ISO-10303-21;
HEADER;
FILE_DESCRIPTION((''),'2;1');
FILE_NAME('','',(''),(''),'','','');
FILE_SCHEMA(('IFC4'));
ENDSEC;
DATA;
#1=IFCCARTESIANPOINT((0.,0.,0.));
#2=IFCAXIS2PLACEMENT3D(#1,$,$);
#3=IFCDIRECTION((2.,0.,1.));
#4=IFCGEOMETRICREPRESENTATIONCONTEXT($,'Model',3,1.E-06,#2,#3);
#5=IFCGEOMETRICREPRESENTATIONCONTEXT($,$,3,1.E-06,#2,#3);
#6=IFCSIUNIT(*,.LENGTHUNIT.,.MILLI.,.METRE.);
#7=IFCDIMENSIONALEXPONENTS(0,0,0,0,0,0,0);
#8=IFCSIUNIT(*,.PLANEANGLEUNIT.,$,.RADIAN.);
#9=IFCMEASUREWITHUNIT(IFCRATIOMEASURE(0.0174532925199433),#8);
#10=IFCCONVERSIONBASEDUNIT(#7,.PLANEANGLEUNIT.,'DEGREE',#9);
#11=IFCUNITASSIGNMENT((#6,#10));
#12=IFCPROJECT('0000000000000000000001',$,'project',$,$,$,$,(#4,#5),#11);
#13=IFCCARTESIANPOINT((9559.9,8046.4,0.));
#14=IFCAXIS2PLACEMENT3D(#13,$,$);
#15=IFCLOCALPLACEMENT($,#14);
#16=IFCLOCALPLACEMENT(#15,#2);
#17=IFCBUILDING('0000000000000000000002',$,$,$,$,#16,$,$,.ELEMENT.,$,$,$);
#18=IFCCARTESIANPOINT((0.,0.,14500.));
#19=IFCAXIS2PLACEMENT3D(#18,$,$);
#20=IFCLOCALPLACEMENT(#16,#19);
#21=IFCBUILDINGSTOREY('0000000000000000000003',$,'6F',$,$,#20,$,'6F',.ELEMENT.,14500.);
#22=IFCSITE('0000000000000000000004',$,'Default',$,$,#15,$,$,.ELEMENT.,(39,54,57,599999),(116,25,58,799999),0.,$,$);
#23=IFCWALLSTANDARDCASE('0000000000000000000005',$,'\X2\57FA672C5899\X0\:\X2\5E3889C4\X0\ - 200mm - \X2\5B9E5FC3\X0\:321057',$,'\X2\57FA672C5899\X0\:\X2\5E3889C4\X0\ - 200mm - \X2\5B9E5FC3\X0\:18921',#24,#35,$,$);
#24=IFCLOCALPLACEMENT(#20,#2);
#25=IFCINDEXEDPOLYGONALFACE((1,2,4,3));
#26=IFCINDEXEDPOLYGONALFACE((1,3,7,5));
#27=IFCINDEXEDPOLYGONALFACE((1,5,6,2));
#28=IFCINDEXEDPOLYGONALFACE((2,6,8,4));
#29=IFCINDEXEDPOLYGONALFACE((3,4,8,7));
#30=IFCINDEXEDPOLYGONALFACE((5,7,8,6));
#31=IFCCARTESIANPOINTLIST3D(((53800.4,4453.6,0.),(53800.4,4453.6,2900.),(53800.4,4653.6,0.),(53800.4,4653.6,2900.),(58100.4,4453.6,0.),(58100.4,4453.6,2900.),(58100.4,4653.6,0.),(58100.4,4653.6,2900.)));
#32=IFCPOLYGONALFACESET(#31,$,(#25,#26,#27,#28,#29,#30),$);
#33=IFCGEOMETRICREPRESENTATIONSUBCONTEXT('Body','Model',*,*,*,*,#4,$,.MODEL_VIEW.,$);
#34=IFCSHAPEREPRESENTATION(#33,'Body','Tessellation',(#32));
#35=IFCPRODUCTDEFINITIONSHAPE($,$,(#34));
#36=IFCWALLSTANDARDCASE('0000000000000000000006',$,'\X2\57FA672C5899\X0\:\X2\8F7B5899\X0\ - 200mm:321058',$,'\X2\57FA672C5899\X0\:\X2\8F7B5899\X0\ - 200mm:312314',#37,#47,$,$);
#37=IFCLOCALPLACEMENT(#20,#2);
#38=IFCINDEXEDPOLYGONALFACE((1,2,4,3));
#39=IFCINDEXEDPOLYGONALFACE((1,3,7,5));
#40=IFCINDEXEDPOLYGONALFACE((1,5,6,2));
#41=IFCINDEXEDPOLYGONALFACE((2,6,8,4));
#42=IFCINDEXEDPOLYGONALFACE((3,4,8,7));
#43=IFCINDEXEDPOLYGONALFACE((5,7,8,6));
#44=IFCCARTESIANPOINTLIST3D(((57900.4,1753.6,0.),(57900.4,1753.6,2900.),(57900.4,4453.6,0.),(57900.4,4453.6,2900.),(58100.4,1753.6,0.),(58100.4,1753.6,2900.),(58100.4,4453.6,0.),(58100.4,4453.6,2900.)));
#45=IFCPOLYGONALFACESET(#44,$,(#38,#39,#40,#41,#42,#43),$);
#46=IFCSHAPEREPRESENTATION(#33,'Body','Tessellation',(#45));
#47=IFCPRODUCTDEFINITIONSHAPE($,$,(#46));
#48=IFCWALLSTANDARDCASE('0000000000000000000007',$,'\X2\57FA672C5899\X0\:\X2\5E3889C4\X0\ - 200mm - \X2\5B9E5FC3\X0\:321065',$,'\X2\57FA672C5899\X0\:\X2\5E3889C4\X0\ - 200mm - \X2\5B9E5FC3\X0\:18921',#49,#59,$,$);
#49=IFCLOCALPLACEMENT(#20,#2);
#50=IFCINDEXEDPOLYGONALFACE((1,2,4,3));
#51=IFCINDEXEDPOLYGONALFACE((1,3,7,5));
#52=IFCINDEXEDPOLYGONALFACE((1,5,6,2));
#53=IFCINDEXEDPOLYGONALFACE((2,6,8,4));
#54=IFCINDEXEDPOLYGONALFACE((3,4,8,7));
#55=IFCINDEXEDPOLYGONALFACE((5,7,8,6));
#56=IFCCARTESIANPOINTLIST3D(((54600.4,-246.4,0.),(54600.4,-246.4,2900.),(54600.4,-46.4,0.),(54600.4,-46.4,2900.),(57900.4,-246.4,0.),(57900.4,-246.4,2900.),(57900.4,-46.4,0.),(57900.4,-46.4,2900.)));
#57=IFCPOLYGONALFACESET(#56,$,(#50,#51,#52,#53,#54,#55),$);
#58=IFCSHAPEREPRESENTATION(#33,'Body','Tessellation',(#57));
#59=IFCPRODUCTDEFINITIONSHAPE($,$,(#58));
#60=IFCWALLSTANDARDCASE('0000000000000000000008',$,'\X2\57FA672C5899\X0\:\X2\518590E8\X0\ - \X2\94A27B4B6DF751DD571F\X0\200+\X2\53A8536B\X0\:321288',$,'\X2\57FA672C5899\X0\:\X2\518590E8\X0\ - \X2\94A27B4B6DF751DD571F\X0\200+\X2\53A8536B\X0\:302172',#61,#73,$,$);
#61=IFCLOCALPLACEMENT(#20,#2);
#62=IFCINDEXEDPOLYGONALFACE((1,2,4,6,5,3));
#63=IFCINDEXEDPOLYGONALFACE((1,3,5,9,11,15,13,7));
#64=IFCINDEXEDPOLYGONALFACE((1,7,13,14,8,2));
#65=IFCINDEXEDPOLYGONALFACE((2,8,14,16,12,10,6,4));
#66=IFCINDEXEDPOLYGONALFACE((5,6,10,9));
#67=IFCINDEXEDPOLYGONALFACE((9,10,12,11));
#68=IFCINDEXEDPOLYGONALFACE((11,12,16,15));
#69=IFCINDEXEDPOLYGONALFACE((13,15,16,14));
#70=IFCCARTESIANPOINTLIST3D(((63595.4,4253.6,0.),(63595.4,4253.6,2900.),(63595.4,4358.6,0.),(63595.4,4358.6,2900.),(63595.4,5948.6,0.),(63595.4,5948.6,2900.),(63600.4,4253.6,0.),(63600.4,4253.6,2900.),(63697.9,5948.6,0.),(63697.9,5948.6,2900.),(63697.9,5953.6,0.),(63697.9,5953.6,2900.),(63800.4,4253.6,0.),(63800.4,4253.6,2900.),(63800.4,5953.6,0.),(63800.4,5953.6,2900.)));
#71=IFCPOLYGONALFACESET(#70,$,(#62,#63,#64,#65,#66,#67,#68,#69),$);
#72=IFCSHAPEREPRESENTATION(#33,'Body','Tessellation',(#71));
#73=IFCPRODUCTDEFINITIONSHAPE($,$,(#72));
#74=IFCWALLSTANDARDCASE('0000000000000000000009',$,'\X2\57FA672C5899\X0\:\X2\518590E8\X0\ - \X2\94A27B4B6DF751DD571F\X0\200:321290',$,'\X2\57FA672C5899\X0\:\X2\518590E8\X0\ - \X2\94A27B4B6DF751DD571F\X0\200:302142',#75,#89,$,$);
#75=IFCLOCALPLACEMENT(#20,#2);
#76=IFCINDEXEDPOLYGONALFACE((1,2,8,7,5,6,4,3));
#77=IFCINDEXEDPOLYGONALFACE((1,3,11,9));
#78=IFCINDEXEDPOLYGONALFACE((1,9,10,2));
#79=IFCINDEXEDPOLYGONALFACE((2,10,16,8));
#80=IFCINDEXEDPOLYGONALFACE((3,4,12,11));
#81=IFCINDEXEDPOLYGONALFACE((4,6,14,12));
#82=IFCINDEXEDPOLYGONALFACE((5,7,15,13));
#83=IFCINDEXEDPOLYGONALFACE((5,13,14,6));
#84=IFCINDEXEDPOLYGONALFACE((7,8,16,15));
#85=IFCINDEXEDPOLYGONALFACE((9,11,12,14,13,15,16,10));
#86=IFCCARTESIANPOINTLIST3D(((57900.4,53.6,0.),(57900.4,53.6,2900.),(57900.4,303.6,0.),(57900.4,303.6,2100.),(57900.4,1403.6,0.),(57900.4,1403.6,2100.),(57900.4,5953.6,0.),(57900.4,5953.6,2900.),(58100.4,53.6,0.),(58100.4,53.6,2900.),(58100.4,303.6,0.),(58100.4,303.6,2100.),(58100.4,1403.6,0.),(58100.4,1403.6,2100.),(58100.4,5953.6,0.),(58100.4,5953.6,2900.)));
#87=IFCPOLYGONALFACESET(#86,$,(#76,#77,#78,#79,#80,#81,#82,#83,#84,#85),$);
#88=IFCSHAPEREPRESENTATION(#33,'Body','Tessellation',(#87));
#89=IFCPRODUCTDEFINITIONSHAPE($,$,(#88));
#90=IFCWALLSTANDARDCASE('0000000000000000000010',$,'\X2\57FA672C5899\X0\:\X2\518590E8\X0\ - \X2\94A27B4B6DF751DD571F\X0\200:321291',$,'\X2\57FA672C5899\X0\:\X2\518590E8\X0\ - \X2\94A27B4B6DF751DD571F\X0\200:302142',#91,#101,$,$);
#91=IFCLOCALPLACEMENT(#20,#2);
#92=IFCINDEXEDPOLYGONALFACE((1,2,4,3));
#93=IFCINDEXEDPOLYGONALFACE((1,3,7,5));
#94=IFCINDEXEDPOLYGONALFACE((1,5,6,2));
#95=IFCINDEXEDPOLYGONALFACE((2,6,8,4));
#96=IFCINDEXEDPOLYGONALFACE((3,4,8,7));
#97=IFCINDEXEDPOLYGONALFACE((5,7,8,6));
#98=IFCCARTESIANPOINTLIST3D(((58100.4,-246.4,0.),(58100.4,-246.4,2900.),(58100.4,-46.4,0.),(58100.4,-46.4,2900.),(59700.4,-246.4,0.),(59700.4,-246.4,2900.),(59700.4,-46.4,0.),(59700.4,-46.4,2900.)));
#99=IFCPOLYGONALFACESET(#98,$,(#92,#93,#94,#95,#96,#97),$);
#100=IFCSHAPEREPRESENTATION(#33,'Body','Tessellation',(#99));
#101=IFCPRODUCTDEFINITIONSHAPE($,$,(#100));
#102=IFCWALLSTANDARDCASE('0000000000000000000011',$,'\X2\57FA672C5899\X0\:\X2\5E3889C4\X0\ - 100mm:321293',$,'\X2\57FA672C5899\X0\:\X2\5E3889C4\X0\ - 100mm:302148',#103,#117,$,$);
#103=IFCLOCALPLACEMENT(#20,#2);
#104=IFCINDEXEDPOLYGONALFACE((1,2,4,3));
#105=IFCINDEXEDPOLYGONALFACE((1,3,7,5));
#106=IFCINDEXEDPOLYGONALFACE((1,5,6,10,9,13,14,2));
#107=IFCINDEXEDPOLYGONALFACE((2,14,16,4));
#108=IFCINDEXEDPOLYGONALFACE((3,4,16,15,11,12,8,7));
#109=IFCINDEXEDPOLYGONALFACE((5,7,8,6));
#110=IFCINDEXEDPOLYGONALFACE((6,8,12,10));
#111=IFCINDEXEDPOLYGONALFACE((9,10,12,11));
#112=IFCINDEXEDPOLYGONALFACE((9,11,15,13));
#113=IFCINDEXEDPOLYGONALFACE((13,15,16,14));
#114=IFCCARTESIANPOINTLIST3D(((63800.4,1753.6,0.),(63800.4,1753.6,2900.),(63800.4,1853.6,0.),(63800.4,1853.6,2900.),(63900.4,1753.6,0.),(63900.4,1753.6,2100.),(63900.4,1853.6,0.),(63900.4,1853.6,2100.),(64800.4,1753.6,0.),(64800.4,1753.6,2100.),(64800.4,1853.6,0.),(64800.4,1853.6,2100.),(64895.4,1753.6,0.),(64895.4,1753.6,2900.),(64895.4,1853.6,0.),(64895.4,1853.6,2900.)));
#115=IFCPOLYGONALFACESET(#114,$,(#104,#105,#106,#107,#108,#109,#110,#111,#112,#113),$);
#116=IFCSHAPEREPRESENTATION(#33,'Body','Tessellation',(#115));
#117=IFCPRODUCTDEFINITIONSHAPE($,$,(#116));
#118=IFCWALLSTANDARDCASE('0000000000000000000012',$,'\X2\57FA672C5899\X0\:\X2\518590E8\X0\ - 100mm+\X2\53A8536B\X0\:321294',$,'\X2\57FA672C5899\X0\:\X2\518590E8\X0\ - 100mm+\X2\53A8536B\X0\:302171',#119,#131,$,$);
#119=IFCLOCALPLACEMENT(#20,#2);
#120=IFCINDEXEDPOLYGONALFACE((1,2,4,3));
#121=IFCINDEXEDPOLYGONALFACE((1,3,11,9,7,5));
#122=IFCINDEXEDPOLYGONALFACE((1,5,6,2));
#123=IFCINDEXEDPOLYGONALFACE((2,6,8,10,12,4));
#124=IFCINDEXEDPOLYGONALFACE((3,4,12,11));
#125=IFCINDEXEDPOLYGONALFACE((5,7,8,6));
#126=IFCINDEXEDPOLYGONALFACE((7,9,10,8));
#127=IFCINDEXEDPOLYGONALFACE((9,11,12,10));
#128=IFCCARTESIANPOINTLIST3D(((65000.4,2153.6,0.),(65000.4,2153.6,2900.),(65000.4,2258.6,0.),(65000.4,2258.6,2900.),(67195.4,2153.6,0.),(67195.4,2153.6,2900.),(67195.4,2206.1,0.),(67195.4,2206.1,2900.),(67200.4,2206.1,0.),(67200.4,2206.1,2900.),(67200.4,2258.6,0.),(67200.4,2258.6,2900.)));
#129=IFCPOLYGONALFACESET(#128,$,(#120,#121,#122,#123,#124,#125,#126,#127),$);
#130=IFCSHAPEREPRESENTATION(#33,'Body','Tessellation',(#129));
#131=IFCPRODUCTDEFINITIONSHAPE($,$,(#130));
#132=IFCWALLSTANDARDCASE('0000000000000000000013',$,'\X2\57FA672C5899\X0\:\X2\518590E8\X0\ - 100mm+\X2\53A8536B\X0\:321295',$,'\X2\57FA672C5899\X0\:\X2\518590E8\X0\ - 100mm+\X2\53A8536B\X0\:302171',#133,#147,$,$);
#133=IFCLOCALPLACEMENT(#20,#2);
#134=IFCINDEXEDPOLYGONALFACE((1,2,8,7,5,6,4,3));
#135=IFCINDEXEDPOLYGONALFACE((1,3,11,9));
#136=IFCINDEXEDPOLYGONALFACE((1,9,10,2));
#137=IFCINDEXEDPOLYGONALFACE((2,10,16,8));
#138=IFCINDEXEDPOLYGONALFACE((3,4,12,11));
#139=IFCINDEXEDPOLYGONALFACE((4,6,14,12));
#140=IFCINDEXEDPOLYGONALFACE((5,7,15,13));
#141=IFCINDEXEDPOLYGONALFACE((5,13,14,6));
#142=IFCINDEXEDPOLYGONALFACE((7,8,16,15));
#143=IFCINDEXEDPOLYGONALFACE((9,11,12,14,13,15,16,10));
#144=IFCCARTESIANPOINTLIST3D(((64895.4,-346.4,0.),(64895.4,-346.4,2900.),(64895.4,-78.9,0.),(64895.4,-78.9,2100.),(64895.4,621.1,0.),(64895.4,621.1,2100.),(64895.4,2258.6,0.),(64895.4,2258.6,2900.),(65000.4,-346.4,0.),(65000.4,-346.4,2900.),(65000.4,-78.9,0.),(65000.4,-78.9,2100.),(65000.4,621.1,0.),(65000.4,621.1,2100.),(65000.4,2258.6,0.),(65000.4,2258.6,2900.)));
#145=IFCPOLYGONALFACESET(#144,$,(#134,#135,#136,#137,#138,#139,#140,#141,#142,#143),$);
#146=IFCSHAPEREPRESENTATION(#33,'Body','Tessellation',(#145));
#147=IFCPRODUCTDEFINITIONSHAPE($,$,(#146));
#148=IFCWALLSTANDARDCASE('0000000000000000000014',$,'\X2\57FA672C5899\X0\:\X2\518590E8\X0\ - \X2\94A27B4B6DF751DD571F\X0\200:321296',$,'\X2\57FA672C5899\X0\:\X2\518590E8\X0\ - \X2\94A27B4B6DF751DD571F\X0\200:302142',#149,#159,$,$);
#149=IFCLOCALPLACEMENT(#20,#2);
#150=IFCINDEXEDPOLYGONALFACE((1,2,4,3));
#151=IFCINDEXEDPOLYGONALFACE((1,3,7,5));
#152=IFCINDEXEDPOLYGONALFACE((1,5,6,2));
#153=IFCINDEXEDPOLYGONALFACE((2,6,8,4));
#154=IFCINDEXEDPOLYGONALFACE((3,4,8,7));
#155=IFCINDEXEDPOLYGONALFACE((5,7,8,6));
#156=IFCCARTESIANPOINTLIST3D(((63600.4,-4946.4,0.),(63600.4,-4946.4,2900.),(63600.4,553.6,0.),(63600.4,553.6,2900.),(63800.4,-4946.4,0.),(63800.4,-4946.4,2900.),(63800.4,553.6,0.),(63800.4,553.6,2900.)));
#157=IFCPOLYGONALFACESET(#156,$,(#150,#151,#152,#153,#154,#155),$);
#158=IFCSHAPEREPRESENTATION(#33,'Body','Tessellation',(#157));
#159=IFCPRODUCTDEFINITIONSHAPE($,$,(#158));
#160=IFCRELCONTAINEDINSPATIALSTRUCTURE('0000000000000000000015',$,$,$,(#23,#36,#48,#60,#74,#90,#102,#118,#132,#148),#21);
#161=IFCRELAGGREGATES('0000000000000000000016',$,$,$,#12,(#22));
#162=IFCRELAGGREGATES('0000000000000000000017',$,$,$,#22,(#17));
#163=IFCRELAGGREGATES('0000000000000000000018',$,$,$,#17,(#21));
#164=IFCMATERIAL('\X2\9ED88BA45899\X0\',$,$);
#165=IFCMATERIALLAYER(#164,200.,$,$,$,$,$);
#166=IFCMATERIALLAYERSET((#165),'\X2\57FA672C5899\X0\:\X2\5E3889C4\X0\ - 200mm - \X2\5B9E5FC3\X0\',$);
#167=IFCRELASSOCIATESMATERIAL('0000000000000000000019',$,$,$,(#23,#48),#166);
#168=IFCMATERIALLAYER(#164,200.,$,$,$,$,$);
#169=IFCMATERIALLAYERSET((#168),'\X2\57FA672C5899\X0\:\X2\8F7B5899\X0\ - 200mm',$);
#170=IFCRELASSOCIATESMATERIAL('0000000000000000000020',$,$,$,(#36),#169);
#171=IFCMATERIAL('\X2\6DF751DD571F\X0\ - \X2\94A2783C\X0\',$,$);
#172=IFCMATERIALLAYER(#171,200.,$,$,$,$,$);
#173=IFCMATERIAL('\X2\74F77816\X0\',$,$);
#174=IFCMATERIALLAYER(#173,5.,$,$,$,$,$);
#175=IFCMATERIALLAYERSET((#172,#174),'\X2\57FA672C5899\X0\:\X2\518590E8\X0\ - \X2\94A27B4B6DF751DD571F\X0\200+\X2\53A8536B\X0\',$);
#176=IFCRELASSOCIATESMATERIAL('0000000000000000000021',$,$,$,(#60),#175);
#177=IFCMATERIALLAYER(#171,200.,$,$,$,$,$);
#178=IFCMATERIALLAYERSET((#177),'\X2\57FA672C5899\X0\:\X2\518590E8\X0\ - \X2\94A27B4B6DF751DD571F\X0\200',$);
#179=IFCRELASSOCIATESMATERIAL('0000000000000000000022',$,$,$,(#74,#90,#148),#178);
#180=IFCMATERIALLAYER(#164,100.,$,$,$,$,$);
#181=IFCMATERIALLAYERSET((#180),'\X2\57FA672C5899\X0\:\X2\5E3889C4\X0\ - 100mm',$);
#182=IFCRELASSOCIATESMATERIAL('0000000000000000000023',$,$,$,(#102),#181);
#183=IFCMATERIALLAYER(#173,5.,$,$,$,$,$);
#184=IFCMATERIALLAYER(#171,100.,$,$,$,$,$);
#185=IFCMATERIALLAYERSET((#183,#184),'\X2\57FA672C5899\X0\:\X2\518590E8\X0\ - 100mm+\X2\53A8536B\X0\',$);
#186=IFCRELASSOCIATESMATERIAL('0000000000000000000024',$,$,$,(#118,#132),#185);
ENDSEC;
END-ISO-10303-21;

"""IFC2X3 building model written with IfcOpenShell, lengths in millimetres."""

from ifc_helpers import new_model, entity, si_unit, converted_unit, direction, frame, frame_2d, origin, place, context, subcontext, project, spatial, polyline, rectangle, outline, extrude, material, layer, layer_set, layer_usage, element, save


model = new_model("IFC2X3")

# Units and contexts
model_context = context("Model", 3, precision=1e-06, world=origin(), true_north=direction((2.0, 0.0, 1.0)))
context_of_model = context(None, 3, precision=1e-06, world=origin(), true_north=direction((2.0, 0.0, 1.0)))
body_context = subcontext(model_context, "Body", "Model", "MODEL_VIEW")
ifc_project = project(units=[si_unit("LENGTHUNIT", "METRE", prefix="MILLI"), converted_unit("PLANEANGLEUNIT", "DEGREE", entity("IfcRatioMeasure", 0.0174532925199433), si_unit("PLANEANGLEUNIT", "RADIAN"), dimensions=[0, 0, 0, 0, 0, 0, 0])], contexts=[model_context, context_of_model])

# Site, building, storey
site_placement = place(None, frame((9559.9, 8046.4, 0.0)))
site = spatial("IfcSite", under=ifc_project, at=site_placement, Name="Default", CompositionType="ELEMENT", RefLatitude=(39, 54, 57, 599999), RefLongitude=(116, 25, 58, 799999), RefElevation=0.0)
building_placement = place(site_placement, origin())
building = spatial("IfcBuilding", under=site, at=building_placement, CompositionType="ELEMENT")
storey_placement = place(building_placement, frame((0.0, 0.0, 14500.0)))
storey = spatial("IfcBuildingStorey", under=building, at=storey_placement, Name="6F", LongName="6F", CompositionType="ELEMENT", Elevation=14500.0)

# Walls
ifc_material_1 = material(Name="默认墙")
ifc_layer_1 = layer(ifc_material_1, 200.0)
ifc_layer_set_1 = layer_set([ifc_layer_1], Name="基本墙:常规 - 200mm - 实心")
ifc_layer_usage_1 = layer_usage(ifc_layer_set_1, "AXIS2", "POSITIVE", -100.0)
wall_1_placement = place(storey_placement, frame((58100.4, 4553.6, 0.0), z_axis=(0.0, 0.0, 1.0), x_axis=(-1.0, 0.0, 0.0)))
element("IfcWallStandardCase", 1, at=wall_1_placement, inside=storey, material=ifc_layer_usage_1, Name="基本墙:常规 - 200mm - 实心:321057", ObjectType="基本墙:常规 - 200mm - 实心:18921", context=body_context, shape_type="SweptSolid", body=[
    extrude(rectangle(XDim=4300.0, YDim=200.0, at=frame_2d((2150.0, 0.0), x_axis=(-1.0, 0.0))), origin(), (0.0, 0.0, 1.0), 2900.0),
])
ifc_layer_2 = layer(ifc_material_1, 200.0)
ifc_layer_set_2 = layer_set([ifc_layer_2], Name="基本墙:轻墙 - 200mm")
ifc_layer_usage_2 = layer_usage(ifc_layer_set_2, "AXIS2", "POSITIVE", -100.0)
wall_2_placement = place(storey_placement, frame((58000.4, 4453.6, 0.0), z_axis=(0.0, 0.0, 1.0), x_axis=(0.0, -1.0, 0.0)))
element("IfcWallStandardCase", 2, at=wall_2_placement, inside=storey, material=ifc_layer_usage_2, Name="基本墙:轻墙 - 200mm:321058", ObjectType="基本墙:轻墙 - 200mm:312314", context=body_context, shape_type="SweptSolid", body=[
    extrude(rectangle(XDim=2700.0, YDim=200.0, at=frame_2d((1350.0, 0.0), x_axis=(-1.0, 0.0))), origin(), (0.0, 0.0, 1.0), 2900.0),
])
ifc_layer_usage_3 = layer_usage(ifc_layer_set_1, "AXIS2", "POSITIVE", -100.0)
wall_3_placement = place(storey_placement, frame((57900.4, -146.4, 0.0), z_axis=(0.0, 0.0, 1.0), x_axis=(-1.0, 0.0, 0.0)))
element("IfcWallStandardCase", 3, at=wall_3_placement, inside=storey, material=ifc_layer_usage_3, Name="基本墙:常规 - 200mm - 实心:321065", ObjectType="基本墙:常规 - 200mm - 实心:18921", context=body_context, shape_type="SweptSolid", body=[
    extrude(rectangle(XDim=3300.0, YDim=200.0, at=frame_2d((1650.0, 0.0), x_axis=(-1.0, 0.0))), origin(), (0.0, 0.0, 1.0), 2900.0),
])

# Shared definitions
ifc_material_2 = material(Name="混凝土 - 钢砼")

# Wall
ifc_layer_3 = layer(ifc_material_2, 200.0)
ifc_material_3 = material(Name="瓷砖")
ifc_layer_4 = layer(ifc_material_3, 5.0)
ifc_layer_set_3 = layer_set([ifc_layer_3, ifc_layer_4], Name="基本墙:内部 - 钢筋混凝土200+厨卫")
ifc_layer_usage_4 = layer_usage(ifc_layer_set_3, "AXIS2", "NEGATIVE", 102.5)
wall_4_placement = place(storey_placement, frame((63697.9, 5953.6, 0.0), z_axis=(0.0, 0.0, 1.0), x_axis=(0.0, -1.0, 0.0)))
element("IfcWallStandardCase", 4, at=wall_4_placement, inside=storey, material=ifc_layer_usage_4, Name="基本墙:内部 - 钢筋混凝土200+厨卫:321288", ObjectType="基本墙:内部 - 钢筋混凝土200+厨卫:302172", context=body_context, shape_type="SweptSolid", body=[
    extrude(outline(polyline([(1700.0, -102.5), (1700.0, -97.5), (1700.0, 102.5), (0.0, 102.5), (0.0, 0.0), (5.0, 0.0), (5.0, -102.5), (1595.0, -102.5), (1700.0, -102.5)])), origin(), (0.0, 0.0, 1.0), 2900.0),
])

# Wall, opening
ifc_layer_5 = layer(ifc_material_2, 200.0)
ifc_layer_set_4 = layer_set([ifc_layer_5], Name="基本墙:内部 - 钢筋混凝土200")
ifc_layer_usage_5 = layer_usage(ifc_layer_set_4, "AXIS2", "POSITIVE", -100.0)
wall_5_placement = place(storey_placement, frame((58000.4, 5953.6, 0.0), z_axis=(0.0, 0.0, 1.0), x_axis=(0.0, -1.0, 0.0)))
wall_5 = element("IfcWallStandardCase", 5, at=wall_5_placement, inside=storey, material=ifc_layer_usage_5, Name="基本墙:内部 - 钢筋混凝土200:321290", ObjectType="基本墙:内部 - 钢筋混凝土200:302142", context=body_context, shape_type="SweptSolid", body=[
    extrude(rectangle(XDim=5900.0, YDim=200.0, at=frame_2d((2950.0, 0.0), x_axis=(-1.0, 0.0))), origin(), (0.0, 0.0, 1.0), 2900.0),
])
opening_1_placement = place(wall_5_placement, frame((5650.0, 100.0, 0.0)))
element("IfcOpeningElement", 6, at=opening_1_placement, cuts=wall_5, ObjectType="Opening", context=body_context, shape_type="SweptSolid", body=[
    extrude(rectangle(XDim=2100.0, YDim=1100.0, at=frame_2d((1050.0, 550.0), x_axis=(1.0, 0.0))), frame((0.0, 0.0, 0.0), z_axis=(0.0, -1.0, 0.0), x_axis=(0.0, 0.0, 1.0)), (0.0, 0.0, 1.0), 200.0),
])

# Wall
ifc_layer_usage_6 = layer_usage(ifc_layer_set_4, "AXIS2", "POSITIVE", -100.0)
wall_6_placement = place(storey_placement, frame((58100.4, -146.4, 0.0)))
element("IfcWallStandardCase", 7, at=wall_6_placement, inside=storey, material=ifc_layer_usage_6, Name="基本墙:内部 - 钢筋混凝土200:321291", ObjectType="基本墙:内部 - 钢筋混凝土200:302142", context=body_context, shape_type="SweptSolid", body=[
    extrude(rectangle(XDim=1600.0, YDim=200.0, at=frame_2d((800.0, 0.0), x_axis=(-1.0, 0.0))), origin(), (0.0, 0.0, 1.0), 2900.0),
])

# Wall, opening
ifc_layer_6 = layer(ifc_material_1, 100.0)
ifc_layer_set_5 = layer_set([ifc_layer_6], Name="基本墙:常规 - 100mm")
ifc_layer_usage_7 = layer_usage(ifc_layer_set_5, "AXIS2", "POSITIVE", -50.0)
wall_7_placement = place(storey_placement, frame((64895.4, 1803.6, 0.0), z_axis=(0.0, 0.0, 1.0), x_axis=(-1.0, 0.0, 0.0)))
wall_7 = element("IfcWallStandardCase", 8, at=wall_7_placement, inside=storey, material=ifc_layer_usage_7, Name="基本墙:常规 - 100mm:321293", ObjectType="基本墙:常规 - 100mm:302148", context=body_context, shape_type="SweptSolid", body=[
    extrude(rectangle(XDim=1095.0, YDim=100.0, at=frame_2d((547.5, 0.0), x_axis=(-1.0, 0.0))), origin(), (0.0, 0.0, 1.0), 2900.0),
])
opening_2_placement = place(wall_7_placement, frame((995.0, 50.0, 0.0)))
element("IfcOpeningElement", 9, at=opening_2_placement, cuts=wall_7, ObjectType="Opening", context=body_context, shape_type="SweptSolid", body=[
    extrude(rectangle(XDim=2100.0, YDim=900.0, at=frame_2d((1050.0, 450.0), x_axis=(1.0, 0.0))), frame((0.0, 0.0, 0.0), z_axis=(0.0, -1.0, 0.0), x_axis=(0.0, 0.0, 1.0)), (0.0, 0.0, 1.0), 100.0),
])

# Wall
ifc_layer_7 = layer(ifc_material_3, 5.0)
ifc_layer_8 = layer(ifc_material_2, 100.0)
ifc_layer_set_6 = layer_set([ifc_layer_7, ifc_layer_8], Name="基本墙:内部 - 100mm+厨卫")
ifc_layer_usage_8 = layer_usage(ifc_layer_set_6, "AXIS2", "NEGATIVE", 52.5)
wall_8_placement = place(storey_placement, frame((67200.4, 2206.1, 0.0), z_axis=(0.0, 0.0, 1.0), x_axis=(-1.0, 0.0, 0.0)))
element("IfcWallStandardCase", 10, at=wall_8_placement, inside=storey, material=ifc_layer_usage_8, Name="基本墙:内部 - 100mm+厨卫:321294", ObjectType="基本墙:内部 - 100mm+厨卫:302171", context=body_context, shape_type="SweptSolid", body=[
    extrude(outline(polyline([(2200.0, -52.5), (2200.0, 52.5), (5.0, 52.5), (5.0, 0.0), (0.0, 0.0), (0.0, -52.5), (2200.0, -52.5)])), origin(), (0.0, 0.0, 1.0), 2900.0),
])

# Wall, opening
ifc_layer_usage_9 = layer_usage(ifc_layer_set_6, "AXIS2", "NEGATIVE", 52.5)
wall_9_placement = place(storey_placement, frame((64947.9, 2258.6, 0.0), z_axis=(0.0, 0.0, 1.0), x_axis=(0.0, -1.0, 0.0)))
wall_9 = element("IfcWallStandardCase", 11, at=wall_9_placement, inside=storey, material=ifc_layer_usage_9, Name="基本墙:内部 - 100mm+厨卫:321295", ObjectType="基本墙:内部 - 100mm+厨卫:302171", context=body_context, shape_type="SweptSolid", body=[
    extrude(rectangle(XDim=2605.0, YDim=105.0, at=frame_2d((1302.5, 0.0), x_axis=(-1.0, 0.0))), origin(), (0.0, 0.0, 1.0), 2900.0),
])
opening_3_placement = place(wall_9_placement, frame((1637.5, -52.5, 0.0)))
element("IfcOpeningElement", 12, at=opening_3_placement, cuts=wall_9, ObjectType="Opening", context=body_context, shape_type="SweptSolid", body=[
    extrude(rectangle(XDim=2100.0, YDim=700.0, at=frame_2d((1050.0, 350.0), x_axis=(1.0, 0.0))), frame((0.0, 0.0, 0.0), z_axis=(0.0, 1.0, 0.0), x_axis=(0.0, 0.0, 1.0)), (0.0, 0.0, 1.0), 105.0),
])

# Wall
ifc_layer_usage_10 = layer_usage(ifc_layer_set_4, "AXIS2", "NEGATIVE", 100.0)
wall_10_placement = place(storey_placement, frame((63700.4, 553.6, 0.0), z_axis=(0.0, 0.0, 1.0), x_axis=(0.0, -1.0, 0.0)))
element("IfcWallStandardCase", 13, at=wall_10_placement, inside=storey, material=ifc_layer_usage_10, Name="基本墙:内部 - 钢筋混凝土200:321296", ObjectType="基本墙:内部 - 钢筋混凝土200:302142", context=body_context, shape_type="SweptSolid", body=[
    extrude(rectangle(XDim=5500.0, YDim=200.0, at=frame_2d((2750.0, 0.0), x_axis=(-1.0, 0.0))), origin(), (0.0, 0.0, 1.0), 2900.0),
])

save(model, "model.ifc")
